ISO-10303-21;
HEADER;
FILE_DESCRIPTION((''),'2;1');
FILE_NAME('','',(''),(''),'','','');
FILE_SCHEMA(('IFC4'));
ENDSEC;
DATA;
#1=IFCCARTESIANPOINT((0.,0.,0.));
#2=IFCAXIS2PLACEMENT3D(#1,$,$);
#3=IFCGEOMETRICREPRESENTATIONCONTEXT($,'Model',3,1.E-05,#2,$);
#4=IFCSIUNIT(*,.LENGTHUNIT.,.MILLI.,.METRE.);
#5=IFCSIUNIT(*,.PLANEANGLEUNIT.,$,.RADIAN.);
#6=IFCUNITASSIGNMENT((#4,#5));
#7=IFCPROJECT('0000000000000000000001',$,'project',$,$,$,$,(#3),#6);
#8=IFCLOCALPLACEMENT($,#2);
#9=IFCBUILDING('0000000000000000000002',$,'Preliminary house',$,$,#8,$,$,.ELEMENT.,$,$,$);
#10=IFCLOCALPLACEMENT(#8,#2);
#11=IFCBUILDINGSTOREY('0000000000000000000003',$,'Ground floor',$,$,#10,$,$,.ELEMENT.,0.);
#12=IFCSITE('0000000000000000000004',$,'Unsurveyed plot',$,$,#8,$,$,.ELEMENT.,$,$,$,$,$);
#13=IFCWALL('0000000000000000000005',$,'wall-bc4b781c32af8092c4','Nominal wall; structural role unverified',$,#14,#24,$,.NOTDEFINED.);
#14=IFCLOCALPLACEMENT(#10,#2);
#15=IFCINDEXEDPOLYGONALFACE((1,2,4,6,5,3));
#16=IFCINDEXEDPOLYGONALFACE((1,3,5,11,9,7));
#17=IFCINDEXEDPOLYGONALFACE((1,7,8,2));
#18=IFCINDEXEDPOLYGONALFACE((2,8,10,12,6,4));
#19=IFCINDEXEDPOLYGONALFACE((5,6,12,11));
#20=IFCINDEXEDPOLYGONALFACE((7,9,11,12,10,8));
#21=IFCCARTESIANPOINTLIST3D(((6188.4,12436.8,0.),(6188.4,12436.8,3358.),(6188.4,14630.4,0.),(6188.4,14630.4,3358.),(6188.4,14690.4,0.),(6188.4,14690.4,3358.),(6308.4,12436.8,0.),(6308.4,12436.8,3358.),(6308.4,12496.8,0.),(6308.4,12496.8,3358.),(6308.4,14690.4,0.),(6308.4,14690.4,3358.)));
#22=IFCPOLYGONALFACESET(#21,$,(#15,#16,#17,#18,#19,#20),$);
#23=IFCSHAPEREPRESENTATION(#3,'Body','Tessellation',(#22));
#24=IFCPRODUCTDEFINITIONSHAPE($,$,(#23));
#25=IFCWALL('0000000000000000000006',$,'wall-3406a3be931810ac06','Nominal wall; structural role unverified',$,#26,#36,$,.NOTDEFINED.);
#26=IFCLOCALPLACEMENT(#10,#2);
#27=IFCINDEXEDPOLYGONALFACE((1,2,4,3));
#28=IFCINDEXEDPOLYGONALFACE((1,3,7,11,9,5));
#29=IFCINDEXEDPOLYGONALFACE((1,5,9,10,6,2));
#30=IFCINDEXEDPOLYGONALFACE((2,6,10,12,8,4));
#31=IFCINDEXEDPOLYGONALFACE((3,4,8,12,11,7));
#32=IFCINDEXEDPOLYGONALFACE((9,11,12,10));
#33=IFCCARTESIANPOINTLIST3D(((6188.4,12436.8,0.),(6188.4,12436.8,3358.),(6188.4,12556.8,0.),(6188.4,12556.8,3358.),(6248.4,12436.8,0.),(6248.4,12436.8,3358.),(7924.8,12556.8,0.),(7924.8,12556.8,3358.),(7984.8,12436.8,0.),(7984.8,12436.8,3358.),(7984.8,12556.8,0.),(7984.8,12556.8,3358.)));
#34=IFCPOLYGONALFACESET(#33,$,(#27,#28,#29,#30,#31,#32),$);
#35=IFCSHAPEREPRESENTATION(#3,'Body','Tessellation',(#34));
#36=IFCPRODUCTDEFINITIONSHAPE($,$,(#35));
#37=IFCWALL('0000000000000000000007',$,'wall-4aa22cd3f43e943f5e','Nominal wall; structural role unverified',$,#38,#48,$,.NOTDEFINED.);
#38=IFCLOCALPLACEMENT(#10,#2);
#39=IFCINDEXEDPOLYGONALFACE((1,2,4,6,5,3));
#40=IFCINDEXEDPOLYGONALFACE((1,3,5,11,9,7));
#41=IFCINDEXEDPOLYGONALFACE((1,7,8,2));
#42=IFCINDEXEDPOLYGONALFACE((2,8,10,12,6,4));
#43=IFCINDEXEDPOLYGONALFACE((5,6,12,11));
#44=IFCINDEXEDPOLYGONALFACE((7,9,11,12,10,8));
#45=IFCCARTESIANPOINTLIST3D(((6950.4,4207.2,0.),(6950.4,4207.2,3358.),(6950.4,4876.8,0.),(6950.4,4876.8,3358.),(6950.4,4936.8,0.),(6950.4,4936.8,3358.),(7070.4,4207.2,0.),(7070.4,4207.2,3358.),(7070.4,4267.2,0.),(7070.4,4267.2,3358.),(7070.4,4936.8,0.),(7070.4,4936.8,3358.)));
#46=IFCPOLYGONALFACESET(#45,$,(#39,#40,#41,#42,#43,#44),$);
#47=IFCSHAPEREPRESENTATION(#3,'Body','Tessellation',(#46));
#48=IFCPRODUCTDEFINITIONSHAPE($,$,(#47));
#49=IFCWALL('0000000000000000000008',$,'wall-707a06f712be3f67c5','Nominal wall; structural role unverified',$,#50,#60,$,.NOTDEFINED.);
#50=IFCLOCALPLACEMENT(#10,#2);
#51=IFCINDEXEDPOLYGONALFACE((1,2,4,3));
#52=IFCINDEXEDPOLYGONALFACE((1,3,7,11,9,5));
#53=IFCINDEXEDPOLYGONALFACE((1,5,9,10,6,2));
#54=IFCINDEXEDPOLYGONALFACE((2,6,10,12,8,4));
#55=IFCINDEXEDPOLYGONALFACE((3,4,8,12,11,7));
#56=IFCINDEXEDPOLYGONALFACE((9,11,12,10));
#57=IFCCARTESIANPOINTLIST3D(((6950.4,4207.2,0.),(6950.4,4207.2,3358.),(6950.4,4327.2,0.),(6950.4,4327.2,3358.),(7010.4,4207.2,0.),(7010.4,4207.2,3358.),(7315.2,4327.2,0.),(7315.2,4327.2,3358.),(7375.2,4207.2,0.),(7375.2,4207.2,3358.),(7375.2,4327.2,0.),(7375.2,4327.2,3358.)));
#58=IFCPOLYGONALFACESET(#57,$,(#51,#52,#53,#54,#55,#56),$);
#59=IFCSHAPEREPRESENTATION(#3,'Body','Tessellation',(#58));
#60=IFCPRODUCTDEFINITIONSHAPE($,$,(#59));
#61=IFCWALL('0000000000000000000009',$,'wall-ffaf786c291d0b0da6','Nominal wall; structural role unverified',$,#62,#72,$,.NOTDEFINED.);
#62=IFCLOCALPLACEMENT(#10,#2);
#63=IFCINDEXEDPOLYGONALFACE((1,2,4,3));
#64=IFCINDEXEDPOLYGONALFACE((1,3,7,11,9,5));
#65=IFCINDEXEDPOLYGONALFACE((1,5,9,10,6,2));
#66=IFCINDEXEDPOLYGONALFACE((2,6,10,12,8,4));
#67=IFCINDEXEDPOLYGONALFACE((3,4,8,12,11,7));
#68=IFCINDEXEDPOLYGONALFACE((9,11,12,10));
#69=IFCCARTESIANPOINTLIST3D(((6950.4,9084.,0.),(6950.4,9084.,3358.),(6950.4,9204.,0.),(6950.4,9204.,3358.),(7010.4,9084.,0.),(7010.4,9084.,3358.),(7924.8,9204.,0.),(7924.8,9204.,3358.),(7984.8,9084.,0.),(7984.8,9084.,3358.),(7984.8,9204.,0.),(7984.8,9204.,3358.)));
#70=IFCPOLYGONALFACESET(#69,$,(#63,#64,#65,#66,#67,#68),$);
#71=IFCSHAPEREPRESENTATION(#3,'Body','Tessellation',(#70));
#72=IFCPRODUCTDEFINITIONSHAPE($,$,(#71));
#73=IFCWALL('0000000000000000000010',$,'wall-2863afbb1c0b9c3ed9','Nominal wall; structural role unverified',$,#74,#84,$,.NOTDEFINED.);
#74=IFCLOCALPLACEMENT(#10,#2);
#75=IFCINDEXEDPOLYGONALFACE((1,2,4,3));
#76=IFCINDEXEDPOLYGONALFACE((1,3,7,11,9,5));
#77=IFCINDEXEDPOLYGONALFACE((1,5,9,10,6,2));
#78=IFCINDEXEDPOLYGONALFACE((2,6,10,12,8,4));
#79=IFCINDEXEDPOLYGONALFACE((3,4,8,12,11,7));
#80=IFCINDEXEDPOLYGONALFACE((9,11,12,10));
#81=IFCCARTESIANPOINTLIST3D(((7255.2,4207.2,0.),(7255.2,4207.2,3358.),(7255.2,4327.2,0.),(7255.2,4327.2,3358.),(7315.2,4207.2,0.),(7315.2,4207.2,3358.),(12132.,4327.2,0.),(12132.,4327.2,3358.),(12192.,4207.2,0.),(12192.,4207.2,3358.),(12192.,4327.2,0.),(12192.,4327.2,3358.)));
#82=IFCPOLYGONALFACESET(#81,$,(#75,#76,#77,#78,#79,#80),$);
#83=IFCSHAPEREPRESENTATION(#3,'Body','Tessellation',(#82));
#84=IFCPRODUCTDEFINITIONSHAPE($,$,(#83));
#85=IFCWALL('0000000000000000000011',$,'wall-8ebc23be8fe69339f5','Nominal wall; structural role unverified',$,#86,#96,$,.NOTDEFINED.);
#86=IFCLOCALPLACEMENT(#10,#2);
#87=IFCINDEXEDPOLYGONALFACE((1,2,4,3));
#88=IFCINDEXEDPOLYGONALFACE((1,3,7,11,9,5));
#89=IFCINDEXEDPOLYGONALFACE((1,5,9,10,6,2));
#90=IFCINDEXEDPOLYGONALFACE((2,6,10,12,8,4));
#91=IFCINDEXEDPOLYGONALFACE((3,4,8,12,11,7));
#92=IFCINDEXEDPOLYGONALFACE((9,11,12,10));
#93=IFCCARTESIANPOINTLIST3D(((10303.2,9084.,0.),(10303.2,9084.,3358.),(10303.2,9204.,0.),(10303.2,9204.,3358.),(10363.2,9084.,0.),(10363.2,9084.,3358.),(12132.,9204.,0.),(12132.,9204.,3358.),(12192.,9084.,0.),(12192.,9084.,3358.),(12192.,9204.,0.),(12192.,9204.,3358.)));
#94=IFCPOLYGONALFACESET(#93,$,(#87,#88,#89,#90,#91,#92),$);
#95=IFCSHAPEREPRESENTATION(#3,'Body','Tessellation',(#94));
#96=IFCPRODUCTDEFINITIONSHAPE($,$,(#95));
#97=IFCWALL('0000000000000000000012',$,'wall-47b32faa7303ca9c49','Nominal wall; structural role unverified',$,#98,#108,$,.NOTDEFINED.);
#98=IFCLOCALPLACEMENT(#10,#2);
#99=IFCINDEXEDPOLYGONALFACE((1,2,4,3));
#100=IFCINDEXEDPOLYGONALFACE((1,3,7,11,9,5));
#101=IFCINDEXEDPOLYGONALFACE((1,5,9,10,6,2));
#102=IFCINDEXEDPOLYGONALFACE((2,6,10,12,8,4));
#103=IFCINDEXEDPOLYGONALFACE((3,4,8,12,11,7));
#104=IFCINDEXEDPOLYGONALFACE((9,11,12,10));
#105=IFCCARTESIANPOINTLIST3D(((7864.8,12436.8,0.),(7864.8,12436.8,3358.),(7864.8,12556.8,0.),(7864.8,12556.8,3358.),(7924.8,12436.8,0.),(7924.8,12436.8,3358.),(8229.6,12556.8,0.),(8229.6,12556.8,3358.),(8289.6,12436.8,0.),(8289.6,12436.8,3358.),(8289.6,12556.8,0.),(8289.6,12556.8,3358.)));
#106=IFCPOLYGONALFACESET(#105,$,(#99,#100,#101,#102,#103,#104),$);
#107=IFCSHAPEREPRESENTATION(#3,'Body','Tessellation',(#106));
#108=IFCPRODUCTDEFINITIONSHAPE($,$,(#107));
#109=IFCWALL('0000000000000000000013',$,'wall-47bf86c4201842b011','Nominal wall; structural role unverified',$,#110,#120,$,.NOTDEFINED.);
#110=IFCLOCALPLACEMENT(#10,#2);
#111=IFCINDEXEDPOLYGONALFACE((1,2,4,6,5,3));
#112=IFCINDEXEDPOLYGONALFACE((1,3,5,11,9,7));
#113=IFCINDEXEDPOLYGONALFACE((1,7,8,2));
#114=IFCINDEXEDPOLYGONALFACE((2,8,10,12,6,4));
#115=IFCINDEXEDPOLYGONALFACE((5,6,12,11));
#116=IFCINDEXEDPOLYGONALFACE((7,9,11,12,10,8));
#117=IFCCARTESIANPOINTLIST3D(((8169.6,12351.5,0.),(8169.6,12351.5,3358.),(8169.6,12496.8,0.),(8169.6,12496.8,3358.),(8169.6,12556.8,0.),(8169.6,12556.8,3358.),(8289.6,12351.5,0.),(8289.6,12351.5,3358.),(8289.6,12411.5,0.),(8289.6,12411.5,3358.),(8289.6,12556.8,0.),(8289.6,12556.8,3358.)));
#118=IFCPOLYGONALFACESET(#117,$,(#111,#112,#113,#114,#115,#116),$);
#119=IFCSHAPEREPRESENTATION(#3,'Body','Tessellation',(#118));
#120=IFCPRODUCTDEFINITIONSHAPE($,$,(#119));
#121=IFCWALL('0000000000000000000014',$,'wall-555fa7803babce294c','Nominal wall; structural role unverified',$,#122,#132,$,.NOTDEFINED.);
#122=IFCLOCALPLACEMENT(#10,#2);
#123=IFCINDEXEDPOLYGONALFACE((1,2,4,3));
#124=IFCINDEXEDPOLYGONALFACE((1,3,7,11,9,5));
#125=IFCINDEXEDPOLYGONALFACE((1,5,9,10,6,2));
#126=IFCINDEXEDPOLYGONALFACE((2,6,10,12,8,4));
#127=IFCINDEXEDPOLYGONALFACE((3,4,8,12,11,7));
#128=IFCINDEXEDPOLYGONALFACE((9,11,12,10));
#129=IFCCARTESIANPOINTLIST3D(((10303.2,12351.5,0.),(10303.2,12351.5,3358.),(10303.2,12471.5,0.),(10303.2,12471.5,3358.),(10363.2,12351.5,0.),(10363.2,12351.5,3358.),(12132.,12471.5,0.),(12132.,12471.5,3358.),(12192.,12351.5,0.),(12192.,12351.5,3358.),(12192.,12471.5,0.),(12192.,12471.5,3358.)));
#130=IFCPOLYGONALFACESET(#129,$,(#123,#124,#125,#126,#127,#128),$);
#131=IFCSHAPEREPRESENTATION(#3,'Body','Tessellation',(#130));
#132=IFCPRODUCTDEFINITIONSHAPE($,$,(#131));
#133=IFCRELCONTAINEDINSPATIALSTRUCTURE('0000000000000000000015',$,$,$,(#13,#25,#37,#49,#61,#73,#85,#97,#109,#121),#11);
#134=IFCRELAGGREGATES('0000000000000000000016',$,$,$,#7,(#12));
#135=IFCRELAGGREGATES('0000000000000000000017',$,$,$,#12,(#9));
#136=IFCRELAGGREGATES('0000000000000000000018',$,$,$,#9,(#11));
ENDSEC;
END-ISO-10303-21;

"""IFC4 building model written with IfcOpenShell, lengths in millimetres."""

from ifc_helpers import new_model, si_unit, origin, place, context, project, spatial, polyline, outline, extrude, element, save


model = new_model("IFC4")

# Units and contexts
model_context = context("Model", 3, precision=1e-05, world=origin())
ifc_project = project(units=[si_unit("LENGTHUNIT", "METRE", prefix="MILLI"), si_unit("PLANEANGLEUNIT", "RADIAN")], contexts=[model_context])

# Site, building, storey
placement_1 = place(None, origin())
site = spatial("IfcSite", under=ifc_project, at=placement_1, Name="Unsurveyed plot", CompositionType="ELEMENT")
building = spatial("IfcBuilding", under=site, at=placement_1, Name="Preliminary house", CompositionType="ELEMENT")
placement_2 = place(placement_1, origin())
storey = spatial("IfcBuildingStorey", under=building, at=placement_2, Name="Ground floor", CompositionType="ELEMENT", Elevation=0.0)

# Walls
element("IfcWall", 1, at=placement_2, inside=storey, Name="wall-bc4b781c32af8092c4", Description="Nominal wall; structural role unverified", PredefinedType="NOTDEFINED", context=model_context, shape_type="SweptSolid", body=[
    extrude(outline(polyline([(6188.4, 14630.4), (6188.4, 14690.4), (6308.4, 14690.4), (6308.4, 12496.8), (6308.4, 12436.8), (6188.4, 12436.8), (6188.4, 14630.4)])), origin(), (0.0, 0.0, 1.0), 3358.0),
])
element("IfcWall", 2, at=placement_2, inside=storey, Name="wall-3406a3be931810ac06", Description="Nominal wall; structural role unverified", PredefinedType="NOTDEFINED", context=model_context, shape_type="SweptSolid", body=[
    extrude(outline(polyline([(7924.8, 12556.8), (7984.8, 12556.8), (7984.8, 12436.8), (6248.4, 12436.8), (6188.4, 12436.8), (6188.4, 12556.8), (7924.8, 12556.8)])), origin(), (0.0, 0.0, 1.0), 3358.0),
])

# Walls
element("IfcWall", 3, at=placement_2, inside=storey, Name="wall-4aa22cd3f43e943f5e", Description="Nominal wall; structural role unverified", PredefinedType="NOTDEFINED", context=model_context, shape_type="SweptSolid", body=[
    extrude(outline(polyline([(6950.4, 4876.8), (6950.4, 4936.8), (7070.4, 4936.8), (7070.4, 4267.2), (7070.4, 4207.2), (6950.4, 4207.2), (6950.4, 4876.8)])), origin(), (0.0, 0.0, 1.0), 3358.0),
])
element("IfcWall", 4, at=placement_2, inside=storey, Name="wall-707a06f712be3f67c5", Description="Nominal wall; structural role unverified", PredefinedType="NOTDEFINED", context=model_context, shape_type="SweptSolid", body=[
    extrude(outline(polyline([(7315.2, 4327.2), (7375.2, 4327.2), (7375.2, 4207.2), (7010.4, 4207.2), (6950.4, 4207.2), (6950.4, 4327.2), (7315.2, 4327.2)])), origin(), (0.0, 0.0, 1.0), 3358.0),
])

# Wall
element("IfcWall", 5, at=placement_2, inside=storey, Name="wall-ffaf786c291d0b0da6", Description="Nominal wall; structural role unverified", PredefinedType="NOTDEFINED", context=model_context, shape_type="SweptSolid", body=[
    extrude(outline(polyline([(7924.8, 9204.0), (7984.8, 9204.0), (7984.8, 9084.0), (7010.4, 9084.0), (6950.4, 9084.0), (6950.4, 9204.0), (7924.8, 9204.0)])), origin(), (0.0, 0.0, 1.0), 3358.0),
])

# Wall
element("IfcWall", 6, at=placement_2, inside=storey, Name="wall-2863afbb1c0b9c3ed9", Description="Nominal wall; structural role unverified", PredefinedType="NOTDEFINED", context=model_context, shape_type="SweptSolid", body=[
    extrude(outline(polyline([(12132.0, 4327.2), (12192.0, 4327.2), (12192.0, 4207.2), (7315.2, 4207.2), (7255.2, 4207.2), (7255.2, 4327.2), (12132.0, 4327.2)])), origin(), (0.0, 0.0, 1.0), 3358.0),
])

# Walls
element("IfcWall", 7, at=placement_2, inside=storey, Name="wall-8ebc23be8fe69339f5", Description="Nominal wall; structural role unverified", PredefinedType="NOTDEFINED", context=model_context, shape_type="SweptSolid", body=[
    extrude(outline(polyline([(12132.0, 9204.0), (12192.0, 9204.0), (12192.0, 9084.0), (10363.2, 9084.0), (10303.2, 9084.0), (10303.2, 9204.0), (12132.0, 9204.0)])), origin(), (0.0, 0.0, 1.0), 3358.0),
])
element("IfcWall", 8, at=placement_2, inside=storey, Name="wall-47b32faa7303ca9c49", Description="Nominal wall; structural role unverified", PredefinedType="NOTDEFINED", context=model_context, shape_type="SweptSolid", body=[
    extrude(outline(polyline([(8229.6, 12556.8), (8289.6, 12556.8), (8289.6, 12436.8), (7924.8, 12436.8), (7864.8, 12436.8), (7864.8, 12556.8), (8229.6, 12556.8)])), origin(), (0.0, 0.0, 1.0), 3358.0),
])
element("IfcWall", 9, at=placement_2, inside=storey, Name="wall-47bf86c4201842b011", Description="Nominal wall; structural role unverified", PredefinedType="NOTDEFINED", context=model_context, shape_type="SweptSolid", body=[
    extrude(outline(polyline([(8169.6, 12496.8), (8169.6, 12556.8), (8289.6, 12556.8), (8289.6, 12411.5), (8289.6, 12351.5), (8169.6, 12351.5), (8169.6, 12496.8)])), origin(), (0.0, 0.0, 1.0), 3358.0),
])

# Wall
element("IfcWall", 10, at=placement_2, inside=storey, Name="wall-555fa7803babce294c", Description="Nominal wall; structural role unverified", PredefinedType="NOTDEFINED", context=model_context, shape_type="SweptSolid", body=[
    extrude(outline(polyline([(12132.0, 12471.5), (12192.0, 12471.5), (12192.0, 12351.5), (10363.2, 12351.5), (10303.2, 12351.5), (10303.2, 12471.5), (12132.0, 12471.5)])), origin(), (0.0, 0.0, 1.0), 3358.0),
])

save(model, "model.ifc")
